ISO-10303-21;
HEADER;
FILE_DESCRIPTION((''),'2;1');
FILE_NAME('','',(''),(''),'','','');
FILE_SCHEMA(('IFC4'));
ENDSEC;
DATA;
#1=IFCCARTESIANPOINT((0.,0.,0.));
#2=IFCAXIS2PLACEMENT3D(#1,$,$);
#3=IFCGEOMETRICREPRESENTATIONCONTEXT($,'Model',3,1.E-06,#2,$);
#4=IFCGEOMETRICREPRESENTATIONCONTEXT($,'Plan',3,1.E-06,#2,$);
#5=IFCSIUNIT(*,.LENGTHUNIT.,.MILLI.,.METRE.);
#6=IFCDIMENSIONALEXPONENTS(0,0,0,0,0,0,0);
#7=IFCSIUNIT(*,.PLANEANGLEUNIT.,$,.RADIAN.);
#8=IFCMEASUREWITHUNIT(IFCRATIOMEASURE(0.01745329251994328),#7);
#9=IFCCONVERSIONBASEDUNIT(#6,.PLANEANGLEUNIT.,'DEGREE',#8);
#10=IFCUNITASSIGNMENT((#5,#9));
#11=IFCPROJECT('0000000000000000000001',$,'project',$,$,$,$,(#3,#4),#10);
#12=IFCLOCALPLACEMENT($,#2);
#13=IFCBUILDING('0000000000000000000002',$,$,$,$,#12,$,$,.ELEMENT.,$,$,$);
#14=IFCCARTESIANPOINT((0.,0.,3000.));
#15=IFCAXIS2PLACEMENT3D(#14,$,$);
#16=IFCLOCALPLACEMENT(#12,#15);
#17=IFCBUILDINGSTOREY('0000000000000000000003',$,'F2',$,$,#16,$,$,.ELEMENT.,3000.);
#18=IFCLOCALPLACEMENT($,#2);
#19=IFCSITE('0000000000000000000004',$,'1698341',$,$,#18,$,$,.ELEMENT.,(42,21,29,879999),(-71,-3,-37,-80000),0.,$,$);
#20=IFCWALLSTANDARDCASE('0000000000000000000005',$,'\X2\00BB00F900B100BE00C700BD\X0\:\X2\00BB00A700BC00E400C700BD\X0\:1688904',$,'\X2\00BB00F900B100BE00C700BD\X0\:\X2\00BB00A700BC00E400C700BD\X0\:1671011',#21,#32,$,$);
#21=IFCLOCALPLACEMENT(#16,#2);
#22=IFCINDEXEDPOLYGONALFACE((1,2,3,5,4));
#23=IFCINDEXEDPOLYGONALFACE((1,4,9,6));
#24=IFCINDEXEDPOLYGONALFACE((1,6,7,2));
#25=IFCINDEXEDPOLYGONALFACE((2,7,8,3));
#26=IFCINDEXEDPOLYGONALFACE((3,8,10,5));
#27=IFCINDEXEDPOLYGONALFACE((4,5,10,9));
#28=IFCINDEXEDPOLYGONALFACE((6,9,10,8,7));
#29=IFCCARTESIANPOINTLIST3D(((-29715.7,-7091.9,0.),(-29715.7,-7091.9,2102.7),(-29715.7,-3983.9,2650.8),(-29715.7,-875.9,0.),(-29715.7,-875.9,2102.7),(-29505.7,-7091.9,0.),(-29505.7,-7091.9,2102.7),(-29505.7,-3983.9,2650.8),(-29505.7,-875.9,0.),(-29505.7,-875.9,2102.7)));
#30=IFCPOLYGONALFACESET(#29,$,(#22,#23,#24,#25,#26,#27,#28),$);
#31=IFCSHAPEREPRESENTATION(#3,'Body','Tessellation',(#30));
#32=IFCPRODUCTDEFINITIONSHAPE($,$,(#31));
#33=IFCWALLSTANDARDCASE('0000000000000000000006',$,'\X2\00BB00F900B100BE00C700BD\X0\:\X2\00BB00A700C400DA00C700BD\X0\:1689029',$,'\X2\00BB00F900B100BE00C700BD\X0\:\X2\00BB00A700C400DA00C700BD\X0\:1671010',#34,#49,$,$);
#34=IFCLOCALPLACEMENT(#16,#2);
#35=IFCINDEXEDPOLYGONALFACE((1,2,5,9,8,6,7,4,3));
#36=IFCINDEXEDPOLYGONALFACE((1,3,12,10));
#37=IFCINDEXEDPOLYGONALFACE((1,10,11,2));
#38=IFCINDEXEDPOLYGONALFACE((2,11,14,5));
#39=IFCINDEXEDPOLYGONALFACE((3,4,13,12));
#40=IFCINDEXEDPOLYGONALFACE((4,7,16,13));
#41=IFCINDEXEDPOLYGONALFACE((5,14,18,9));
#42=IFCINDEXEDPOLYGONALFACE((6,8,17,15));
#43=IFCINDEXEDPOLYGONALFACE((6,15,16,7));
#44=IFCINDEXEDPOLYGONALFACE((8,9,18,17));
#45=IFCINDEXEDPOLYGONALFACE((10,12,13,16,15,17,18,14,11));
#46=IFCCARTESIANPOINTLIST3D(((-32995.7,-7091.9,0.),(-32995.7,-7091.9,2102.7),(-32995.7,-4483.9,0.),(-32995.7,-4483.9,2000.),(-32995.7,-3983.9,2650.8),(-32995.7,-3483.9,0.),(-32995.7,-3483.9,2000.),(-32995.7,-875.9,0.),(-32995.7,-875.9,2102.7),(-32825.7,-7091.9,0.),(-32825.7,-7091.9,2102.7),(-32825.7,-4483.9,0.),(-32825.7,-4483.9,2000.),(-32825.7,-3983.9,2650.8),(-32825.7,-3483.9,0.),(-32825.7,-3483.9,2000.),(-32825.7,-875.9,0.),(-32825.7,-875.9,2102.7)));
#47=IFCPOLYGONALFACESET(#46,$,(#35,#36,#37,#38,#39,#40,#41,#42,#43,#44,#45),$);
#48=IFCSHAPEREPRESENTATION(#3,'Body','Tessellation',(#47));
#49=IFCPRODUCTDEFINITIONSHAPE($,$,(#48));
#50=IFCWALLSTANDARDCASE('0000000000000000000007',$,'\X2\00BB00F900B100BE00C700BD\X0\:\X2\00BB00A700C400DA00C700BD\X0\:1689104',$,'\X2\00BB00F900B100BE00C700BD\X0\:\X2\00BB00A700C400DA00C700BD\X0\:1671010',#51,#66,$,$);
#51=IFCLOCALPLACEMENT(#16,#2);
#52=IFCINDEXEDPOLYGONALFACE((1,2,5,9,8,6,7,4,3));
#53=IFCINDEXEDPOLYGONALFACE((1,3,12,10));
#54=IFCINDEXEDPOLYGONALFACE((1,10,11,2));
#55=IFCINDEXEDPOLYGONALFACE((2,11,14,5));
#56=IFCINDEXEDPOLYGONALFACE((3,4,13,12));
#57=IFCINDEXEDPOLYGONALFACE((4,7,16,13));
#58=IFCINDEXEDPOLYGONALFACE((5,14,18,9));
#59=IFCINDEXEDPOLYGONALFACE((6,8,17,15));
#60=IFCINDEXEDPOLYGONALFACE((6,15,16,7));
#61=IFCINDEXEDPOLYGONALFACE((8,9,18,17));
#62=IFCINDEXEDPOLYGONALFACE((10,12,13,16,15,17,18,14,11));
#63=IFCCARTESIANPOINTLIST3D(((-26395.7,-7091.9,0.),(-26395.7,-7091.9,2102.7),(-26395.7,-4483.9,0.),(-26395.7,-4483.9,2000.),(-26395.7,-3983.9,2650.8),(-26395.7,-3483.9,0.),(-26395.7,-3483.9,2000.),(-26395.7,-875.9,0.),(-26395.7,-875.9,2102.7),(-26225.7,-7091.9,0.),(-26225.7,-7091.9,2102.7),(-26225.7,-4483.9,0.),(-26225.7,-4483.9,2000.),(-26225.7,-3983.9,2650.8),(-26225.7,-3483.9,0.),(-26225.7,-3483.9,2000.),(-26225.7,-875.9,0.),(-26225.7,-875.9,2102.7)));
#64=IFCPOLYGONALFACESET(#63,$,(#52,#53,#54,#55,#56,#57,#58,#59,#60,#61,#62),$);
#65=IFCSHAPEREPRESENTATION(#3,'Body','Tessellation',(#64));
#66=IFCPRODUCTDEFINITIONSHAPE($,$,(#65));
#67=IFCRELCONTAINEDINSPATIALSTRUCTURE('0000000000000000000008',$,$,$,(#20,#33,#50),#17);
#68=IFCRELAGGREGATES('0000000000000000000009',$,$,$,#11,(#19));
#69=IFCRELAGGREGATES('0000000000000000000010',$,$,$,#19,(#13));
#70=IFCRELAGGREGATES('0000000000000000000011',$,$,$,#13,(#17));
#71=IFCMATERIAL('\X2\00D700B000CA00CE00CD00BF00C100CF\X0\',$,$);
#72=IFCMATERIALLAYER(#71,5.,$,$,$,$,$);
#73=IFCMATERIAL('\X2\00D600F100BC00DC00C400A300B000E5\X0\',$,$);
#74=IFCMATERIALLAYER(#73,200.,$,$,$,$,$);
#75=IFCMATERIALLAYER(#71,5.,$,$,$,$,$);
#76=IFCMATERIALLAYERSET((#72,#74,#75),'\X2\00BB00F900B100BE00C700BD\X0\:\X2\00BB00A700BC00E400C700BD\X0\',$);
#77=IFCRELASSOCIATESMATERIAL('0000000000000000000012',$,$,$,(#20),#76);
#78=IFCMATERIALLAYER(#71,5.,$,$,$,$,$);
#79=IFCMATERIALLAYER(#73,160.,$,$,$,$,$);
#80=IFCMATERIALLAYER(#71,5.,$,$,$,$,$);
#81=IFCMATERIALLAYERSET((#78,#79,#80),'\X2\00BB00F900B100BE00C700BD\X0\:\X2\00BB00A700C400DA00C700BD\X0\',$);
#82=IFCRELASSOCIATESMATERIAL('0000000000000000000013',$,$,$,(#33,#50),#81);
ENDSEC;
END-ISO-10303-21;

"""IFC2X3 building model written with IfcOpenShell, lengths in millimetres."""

from ifc_helpers import new_model, entity, si_unit, converted_unit, frame, frame_2d, origin, place, context, project, spatial, polyline, rectangle, extrude, clip, bounded_halfspace, material, layer, layer_set, layer_usage, element, save


model = new_model("IFC2X3")

# Units and contexts
model_context = context("Model", 3, precision=1e-06, world=origin())
plan_context = context("Plan", 3, precision=1e-06, world=origin())
ifc_project = project(units=[si_unit("LENGTHUNIT", "METRE", prefix="MILLI"), converted_unit("PLANEANGLEUNIT", "DEGREE", entity("IfcRatioMeasure", 0.01745329251994328), si_unit("PLANEANGLEUNIT", "RADIAN"), dimensions=[0, 0, 0, 0, 0, 0, 0])], contexts=[model_context, plan_context])

# Site, building, storey
site_placement = place(None, origin())
site = spatial("IfcSite", under=ifc_project, at=site_placement, Name="1698341", CompositionType="ELEMENT", RefLatitude=(42, 21, 29, 879999), RefLongitude=(-71, -3, -37, -80000), RefElevation=0.0)
building_placement = place(None, origin())
building = spatial("IfcBuilding", under=site, at=building_placement, CompositionType="ELEMENT")
storey_placement = place(building_placement, frame((0.0, 0.0, 3000.0)))
storey = spatial("IfcBuildingStorey", under=building, at=storey_placement, Name="F2", CompositionType="ELEMENT", Elevation=3000.0)

# Shared definitions
ifc_material_1 = material(Name="Öñ¼ÜÄ£°å")

# Shared definitions
ifc_material_2 = material(Name="×°ÊÎÍ¿ÁÏ")

# Wall
ifc_layer_1 = layer(ifc_material_2, 5.0)
ifc_layer_2 = layer(ifc_material_1, 200.0)
ifc_layer_3 = layer(ifc_material_2, 5.0)
ifc_layer_set_1 = layer_set([ifc_layer_1, ifc_layer_2, ifc_layer_3], Name="»ù±¾Ç½:»§¼äÇ½")
ifc_layer_usage_1 = layer_usage(ifc_layer_set_1, "AXIS2", "NEGATIVE", 105.0)
wall_1_placement = place(storey_placement, frame((-29610.7, -7091.9, 0.0), z_axis=(0.0, 0.0, 1.0), x_axis=(0.0, 1.0, 0.0)))
element("IfcWallStandardCase", 1, at=wall_1_placement, inside=storey, material=ifc_layer_usage_1, Name="»ù±¾Ç½:»§¼äÇ½:1688904", ObjectType="»ù±¾Ç½:»§¼äÇ½:1671011", context=model_context, shape_type="Clipping", body=[
    clip(clip(extrude(rectangle(XDim=6216.0, YDim=210.0, at=frame_2d((3108.0, 0.0), x_axis=(-1.0, 0.0))), origin(), (0.0, 0.0, 1.0), 3200.0), bounded_halfspace(frame((0.0, -105.0, 2102.7), z_axis=(0.173648, 0.0, -0.984808), x_axis=(0.0, 1.0, 0.0)), True, frame((0.0, -105.0, 2102.7)), polyline([(0.0, 0.0), (3108.0, 0.0), (3108.0, 210.0), (0.0, 210.0), (0.0, 0.0)]))), bounded_halfspace(frame((3108.0, -105.0, 2650.8), z_axis=(-0.173648, 0.0, -0.984808), x_axis=(0.0, 1.0, 0.0)), True, frame((3108.0, -105.0, 2650.8)), polyline([(0.0, 0.0), (3108.0, 0.0), (3108.0, 210.0), (0.0, 210.0), (0.0, 0.0)]))),
])

# Walls, openings
ifc_layer_4 = layer(ifc_material_2, 5.0)
ifc_layer_5 = layer(ifc_material_1, 160.0)
ifc_layer_6 = layer(ifc_material_2, 5.0)
ifc_layer_set_2 = layer_set([ifc_layer_4, ifc_layer_5, ifc_layer_6], Name="»ù±¾Ç½:»§ÄÚÇ½")
ifc_layer_usage_2 = layer_usage(ifc_layer_set_2, "AXIS2", "NEGATIVE", 85.0)
wall_2_placement = place(storey_placement, frame((-32910.7, -7091.9, 0.0), z_axis=(0.0, 0.0, 1.0), x_axis=(0.0, 1.0, 0.0)))
wall_2 = element("IfcWallStandardCase", 2, at=wall_2_placement, inside=storey, material=ifc_layer_usage_2, Name="»ù±¾Ç½:»§ÄÚÇ½:1689029", ObjectType="»ù±¾Ç½:»§ÄÚÇ½:1671010", context=model_context, shape_type="Clipping", body=[
    clip(clip(extrude(rectangle(XDim=6216.0, YDim=170.0, at=frame_2d((3108.0, 0.0), x_axis=(-1.0, 0.0))), origin(), (0.0, 0.0, 1.0), 3200.0), bounded_halfspace(frame((0.0, -85.0, 2102.7), z_axis=(0.173648, 0.0, -0.984808), x_axis=(0.0, 1.0, 0.0)), True, frame((0.0, -85.0, 2102.7)), polyline([(0.0, 0.0), (3108.0, 0.0), (3108.0, 170.0), (0.0, 170.0), (0.0, 0.0)]))), bounded_halfspace(frame((3108.0, -85.0, 2650.8), z_axis=(-0.173648, 0.0, -0.984808), x_axis=(0.0, 1.0, 0.0)), True, frame((3108.0, -85.0, 2650.8)), polyline([(0.0, 0.0), (3108.0, 0.0), (3108.0, 170.0), (0.0, 170.0), (0.0, 0.0)]))),
])
opening_1_placement = place(wall_2_placement, frame((2608.0, -85.0, 0.0)))
element("IfcOpeningElement", 3, at=opening_1_placement, cuts=wall_2, ObjectType="Opening", context=model_context, shape_type="SweptSolid", body=[
    extrude(rectangle(XDim=1000.0, YDim=2000.0, at=frame_2d((1000.0, 500.0), x_axis=(0.0, -1.0))), frame((0.0, 0.0, 0.0), z_axis=(0.0, 1.0, 0.0), x_axis=(0.0, 0.0, 1.0)), (0.0, 0.0, 1.0), 170.0),
])
ifc_layer_usage_3 = layer_usage(ifc_layer_set_2, "AXIS2", "POSITIVE", -85.0)
wall_3_placement = place(storey_placement, frame((-26310.7, -7091.9, 0.0), z_axis=(0.0, 0.0, 1.0), x_axis=(0.0, 1.0, 0.0)))
wall_3 = element("IfcWallStandardCase", 4, at=wall_3_placement, inside=storey, material=ifc_layer_usage_3, Name="»ù±¾Ç½:»§ÄÚÇ½:1689104", ObjectType="»ù±¾Ç½:»§ÄÚÇ½:1671010", context=model_context, shape_type="Clipping", body=[
    clip(clip(extrude(rectangle(XDim=6216.0, YDim=170.0, at=frame_2d((3108.0, 0.0), x_axis=(-1.0, 0.0))), origin(), (0.0, 0.0, 1.0), 3200.0), bounded_halfspace(frame((0.0, -85.0, 2102.7), z_axis=(0.173648, 0.0, -0.984808), x_axis=(0.0, 1.0, 0.0)), True, frame((0.0, -85.0, 2102.7)), polyline([(0.0, 0.0), (3108.0, 0.0), (3108.0, 170.0), (0.0, 170.0), (0.0, 0.0)]))), bounded_halfspace(frame((3108.0, -85.0, 2650.8), z_axis=(-0.173648, 0.0, -0.984808), x_axis=(0.0, 1.0, 0.0)), True, frame((3108.0, -85.0, 2650.8)), polyline([(0.0, 0.0), (3108.0, 0.0), (3108.0, 170.0), (0.0, 170.0), (0.0, 0.0)]))),
])
opening_2_placement = place(wall_3_placement, frame((3608.0, 85.0, 0.0)))
element("IfcOpeningElement", 5, at=opening_2_placement, cuts=wall_3, ObjectType="Opening", context=model_context, shape_type="SweptSolid", body=[
    extrude(rectangle(XDim=1000.0, YDim=2000.0, at=frame_2d((1000.0, 500.0), x_axis=(0.0, 1.0))), frame((0.0, 0.0, 0.0), z_axis=(0.0, -1.0, 0.0), x_axis=(0.0, 0.0, 1.0)), (0.0, 0.0, 1.0), 170.0),
])

save(model, "model.ifc")
